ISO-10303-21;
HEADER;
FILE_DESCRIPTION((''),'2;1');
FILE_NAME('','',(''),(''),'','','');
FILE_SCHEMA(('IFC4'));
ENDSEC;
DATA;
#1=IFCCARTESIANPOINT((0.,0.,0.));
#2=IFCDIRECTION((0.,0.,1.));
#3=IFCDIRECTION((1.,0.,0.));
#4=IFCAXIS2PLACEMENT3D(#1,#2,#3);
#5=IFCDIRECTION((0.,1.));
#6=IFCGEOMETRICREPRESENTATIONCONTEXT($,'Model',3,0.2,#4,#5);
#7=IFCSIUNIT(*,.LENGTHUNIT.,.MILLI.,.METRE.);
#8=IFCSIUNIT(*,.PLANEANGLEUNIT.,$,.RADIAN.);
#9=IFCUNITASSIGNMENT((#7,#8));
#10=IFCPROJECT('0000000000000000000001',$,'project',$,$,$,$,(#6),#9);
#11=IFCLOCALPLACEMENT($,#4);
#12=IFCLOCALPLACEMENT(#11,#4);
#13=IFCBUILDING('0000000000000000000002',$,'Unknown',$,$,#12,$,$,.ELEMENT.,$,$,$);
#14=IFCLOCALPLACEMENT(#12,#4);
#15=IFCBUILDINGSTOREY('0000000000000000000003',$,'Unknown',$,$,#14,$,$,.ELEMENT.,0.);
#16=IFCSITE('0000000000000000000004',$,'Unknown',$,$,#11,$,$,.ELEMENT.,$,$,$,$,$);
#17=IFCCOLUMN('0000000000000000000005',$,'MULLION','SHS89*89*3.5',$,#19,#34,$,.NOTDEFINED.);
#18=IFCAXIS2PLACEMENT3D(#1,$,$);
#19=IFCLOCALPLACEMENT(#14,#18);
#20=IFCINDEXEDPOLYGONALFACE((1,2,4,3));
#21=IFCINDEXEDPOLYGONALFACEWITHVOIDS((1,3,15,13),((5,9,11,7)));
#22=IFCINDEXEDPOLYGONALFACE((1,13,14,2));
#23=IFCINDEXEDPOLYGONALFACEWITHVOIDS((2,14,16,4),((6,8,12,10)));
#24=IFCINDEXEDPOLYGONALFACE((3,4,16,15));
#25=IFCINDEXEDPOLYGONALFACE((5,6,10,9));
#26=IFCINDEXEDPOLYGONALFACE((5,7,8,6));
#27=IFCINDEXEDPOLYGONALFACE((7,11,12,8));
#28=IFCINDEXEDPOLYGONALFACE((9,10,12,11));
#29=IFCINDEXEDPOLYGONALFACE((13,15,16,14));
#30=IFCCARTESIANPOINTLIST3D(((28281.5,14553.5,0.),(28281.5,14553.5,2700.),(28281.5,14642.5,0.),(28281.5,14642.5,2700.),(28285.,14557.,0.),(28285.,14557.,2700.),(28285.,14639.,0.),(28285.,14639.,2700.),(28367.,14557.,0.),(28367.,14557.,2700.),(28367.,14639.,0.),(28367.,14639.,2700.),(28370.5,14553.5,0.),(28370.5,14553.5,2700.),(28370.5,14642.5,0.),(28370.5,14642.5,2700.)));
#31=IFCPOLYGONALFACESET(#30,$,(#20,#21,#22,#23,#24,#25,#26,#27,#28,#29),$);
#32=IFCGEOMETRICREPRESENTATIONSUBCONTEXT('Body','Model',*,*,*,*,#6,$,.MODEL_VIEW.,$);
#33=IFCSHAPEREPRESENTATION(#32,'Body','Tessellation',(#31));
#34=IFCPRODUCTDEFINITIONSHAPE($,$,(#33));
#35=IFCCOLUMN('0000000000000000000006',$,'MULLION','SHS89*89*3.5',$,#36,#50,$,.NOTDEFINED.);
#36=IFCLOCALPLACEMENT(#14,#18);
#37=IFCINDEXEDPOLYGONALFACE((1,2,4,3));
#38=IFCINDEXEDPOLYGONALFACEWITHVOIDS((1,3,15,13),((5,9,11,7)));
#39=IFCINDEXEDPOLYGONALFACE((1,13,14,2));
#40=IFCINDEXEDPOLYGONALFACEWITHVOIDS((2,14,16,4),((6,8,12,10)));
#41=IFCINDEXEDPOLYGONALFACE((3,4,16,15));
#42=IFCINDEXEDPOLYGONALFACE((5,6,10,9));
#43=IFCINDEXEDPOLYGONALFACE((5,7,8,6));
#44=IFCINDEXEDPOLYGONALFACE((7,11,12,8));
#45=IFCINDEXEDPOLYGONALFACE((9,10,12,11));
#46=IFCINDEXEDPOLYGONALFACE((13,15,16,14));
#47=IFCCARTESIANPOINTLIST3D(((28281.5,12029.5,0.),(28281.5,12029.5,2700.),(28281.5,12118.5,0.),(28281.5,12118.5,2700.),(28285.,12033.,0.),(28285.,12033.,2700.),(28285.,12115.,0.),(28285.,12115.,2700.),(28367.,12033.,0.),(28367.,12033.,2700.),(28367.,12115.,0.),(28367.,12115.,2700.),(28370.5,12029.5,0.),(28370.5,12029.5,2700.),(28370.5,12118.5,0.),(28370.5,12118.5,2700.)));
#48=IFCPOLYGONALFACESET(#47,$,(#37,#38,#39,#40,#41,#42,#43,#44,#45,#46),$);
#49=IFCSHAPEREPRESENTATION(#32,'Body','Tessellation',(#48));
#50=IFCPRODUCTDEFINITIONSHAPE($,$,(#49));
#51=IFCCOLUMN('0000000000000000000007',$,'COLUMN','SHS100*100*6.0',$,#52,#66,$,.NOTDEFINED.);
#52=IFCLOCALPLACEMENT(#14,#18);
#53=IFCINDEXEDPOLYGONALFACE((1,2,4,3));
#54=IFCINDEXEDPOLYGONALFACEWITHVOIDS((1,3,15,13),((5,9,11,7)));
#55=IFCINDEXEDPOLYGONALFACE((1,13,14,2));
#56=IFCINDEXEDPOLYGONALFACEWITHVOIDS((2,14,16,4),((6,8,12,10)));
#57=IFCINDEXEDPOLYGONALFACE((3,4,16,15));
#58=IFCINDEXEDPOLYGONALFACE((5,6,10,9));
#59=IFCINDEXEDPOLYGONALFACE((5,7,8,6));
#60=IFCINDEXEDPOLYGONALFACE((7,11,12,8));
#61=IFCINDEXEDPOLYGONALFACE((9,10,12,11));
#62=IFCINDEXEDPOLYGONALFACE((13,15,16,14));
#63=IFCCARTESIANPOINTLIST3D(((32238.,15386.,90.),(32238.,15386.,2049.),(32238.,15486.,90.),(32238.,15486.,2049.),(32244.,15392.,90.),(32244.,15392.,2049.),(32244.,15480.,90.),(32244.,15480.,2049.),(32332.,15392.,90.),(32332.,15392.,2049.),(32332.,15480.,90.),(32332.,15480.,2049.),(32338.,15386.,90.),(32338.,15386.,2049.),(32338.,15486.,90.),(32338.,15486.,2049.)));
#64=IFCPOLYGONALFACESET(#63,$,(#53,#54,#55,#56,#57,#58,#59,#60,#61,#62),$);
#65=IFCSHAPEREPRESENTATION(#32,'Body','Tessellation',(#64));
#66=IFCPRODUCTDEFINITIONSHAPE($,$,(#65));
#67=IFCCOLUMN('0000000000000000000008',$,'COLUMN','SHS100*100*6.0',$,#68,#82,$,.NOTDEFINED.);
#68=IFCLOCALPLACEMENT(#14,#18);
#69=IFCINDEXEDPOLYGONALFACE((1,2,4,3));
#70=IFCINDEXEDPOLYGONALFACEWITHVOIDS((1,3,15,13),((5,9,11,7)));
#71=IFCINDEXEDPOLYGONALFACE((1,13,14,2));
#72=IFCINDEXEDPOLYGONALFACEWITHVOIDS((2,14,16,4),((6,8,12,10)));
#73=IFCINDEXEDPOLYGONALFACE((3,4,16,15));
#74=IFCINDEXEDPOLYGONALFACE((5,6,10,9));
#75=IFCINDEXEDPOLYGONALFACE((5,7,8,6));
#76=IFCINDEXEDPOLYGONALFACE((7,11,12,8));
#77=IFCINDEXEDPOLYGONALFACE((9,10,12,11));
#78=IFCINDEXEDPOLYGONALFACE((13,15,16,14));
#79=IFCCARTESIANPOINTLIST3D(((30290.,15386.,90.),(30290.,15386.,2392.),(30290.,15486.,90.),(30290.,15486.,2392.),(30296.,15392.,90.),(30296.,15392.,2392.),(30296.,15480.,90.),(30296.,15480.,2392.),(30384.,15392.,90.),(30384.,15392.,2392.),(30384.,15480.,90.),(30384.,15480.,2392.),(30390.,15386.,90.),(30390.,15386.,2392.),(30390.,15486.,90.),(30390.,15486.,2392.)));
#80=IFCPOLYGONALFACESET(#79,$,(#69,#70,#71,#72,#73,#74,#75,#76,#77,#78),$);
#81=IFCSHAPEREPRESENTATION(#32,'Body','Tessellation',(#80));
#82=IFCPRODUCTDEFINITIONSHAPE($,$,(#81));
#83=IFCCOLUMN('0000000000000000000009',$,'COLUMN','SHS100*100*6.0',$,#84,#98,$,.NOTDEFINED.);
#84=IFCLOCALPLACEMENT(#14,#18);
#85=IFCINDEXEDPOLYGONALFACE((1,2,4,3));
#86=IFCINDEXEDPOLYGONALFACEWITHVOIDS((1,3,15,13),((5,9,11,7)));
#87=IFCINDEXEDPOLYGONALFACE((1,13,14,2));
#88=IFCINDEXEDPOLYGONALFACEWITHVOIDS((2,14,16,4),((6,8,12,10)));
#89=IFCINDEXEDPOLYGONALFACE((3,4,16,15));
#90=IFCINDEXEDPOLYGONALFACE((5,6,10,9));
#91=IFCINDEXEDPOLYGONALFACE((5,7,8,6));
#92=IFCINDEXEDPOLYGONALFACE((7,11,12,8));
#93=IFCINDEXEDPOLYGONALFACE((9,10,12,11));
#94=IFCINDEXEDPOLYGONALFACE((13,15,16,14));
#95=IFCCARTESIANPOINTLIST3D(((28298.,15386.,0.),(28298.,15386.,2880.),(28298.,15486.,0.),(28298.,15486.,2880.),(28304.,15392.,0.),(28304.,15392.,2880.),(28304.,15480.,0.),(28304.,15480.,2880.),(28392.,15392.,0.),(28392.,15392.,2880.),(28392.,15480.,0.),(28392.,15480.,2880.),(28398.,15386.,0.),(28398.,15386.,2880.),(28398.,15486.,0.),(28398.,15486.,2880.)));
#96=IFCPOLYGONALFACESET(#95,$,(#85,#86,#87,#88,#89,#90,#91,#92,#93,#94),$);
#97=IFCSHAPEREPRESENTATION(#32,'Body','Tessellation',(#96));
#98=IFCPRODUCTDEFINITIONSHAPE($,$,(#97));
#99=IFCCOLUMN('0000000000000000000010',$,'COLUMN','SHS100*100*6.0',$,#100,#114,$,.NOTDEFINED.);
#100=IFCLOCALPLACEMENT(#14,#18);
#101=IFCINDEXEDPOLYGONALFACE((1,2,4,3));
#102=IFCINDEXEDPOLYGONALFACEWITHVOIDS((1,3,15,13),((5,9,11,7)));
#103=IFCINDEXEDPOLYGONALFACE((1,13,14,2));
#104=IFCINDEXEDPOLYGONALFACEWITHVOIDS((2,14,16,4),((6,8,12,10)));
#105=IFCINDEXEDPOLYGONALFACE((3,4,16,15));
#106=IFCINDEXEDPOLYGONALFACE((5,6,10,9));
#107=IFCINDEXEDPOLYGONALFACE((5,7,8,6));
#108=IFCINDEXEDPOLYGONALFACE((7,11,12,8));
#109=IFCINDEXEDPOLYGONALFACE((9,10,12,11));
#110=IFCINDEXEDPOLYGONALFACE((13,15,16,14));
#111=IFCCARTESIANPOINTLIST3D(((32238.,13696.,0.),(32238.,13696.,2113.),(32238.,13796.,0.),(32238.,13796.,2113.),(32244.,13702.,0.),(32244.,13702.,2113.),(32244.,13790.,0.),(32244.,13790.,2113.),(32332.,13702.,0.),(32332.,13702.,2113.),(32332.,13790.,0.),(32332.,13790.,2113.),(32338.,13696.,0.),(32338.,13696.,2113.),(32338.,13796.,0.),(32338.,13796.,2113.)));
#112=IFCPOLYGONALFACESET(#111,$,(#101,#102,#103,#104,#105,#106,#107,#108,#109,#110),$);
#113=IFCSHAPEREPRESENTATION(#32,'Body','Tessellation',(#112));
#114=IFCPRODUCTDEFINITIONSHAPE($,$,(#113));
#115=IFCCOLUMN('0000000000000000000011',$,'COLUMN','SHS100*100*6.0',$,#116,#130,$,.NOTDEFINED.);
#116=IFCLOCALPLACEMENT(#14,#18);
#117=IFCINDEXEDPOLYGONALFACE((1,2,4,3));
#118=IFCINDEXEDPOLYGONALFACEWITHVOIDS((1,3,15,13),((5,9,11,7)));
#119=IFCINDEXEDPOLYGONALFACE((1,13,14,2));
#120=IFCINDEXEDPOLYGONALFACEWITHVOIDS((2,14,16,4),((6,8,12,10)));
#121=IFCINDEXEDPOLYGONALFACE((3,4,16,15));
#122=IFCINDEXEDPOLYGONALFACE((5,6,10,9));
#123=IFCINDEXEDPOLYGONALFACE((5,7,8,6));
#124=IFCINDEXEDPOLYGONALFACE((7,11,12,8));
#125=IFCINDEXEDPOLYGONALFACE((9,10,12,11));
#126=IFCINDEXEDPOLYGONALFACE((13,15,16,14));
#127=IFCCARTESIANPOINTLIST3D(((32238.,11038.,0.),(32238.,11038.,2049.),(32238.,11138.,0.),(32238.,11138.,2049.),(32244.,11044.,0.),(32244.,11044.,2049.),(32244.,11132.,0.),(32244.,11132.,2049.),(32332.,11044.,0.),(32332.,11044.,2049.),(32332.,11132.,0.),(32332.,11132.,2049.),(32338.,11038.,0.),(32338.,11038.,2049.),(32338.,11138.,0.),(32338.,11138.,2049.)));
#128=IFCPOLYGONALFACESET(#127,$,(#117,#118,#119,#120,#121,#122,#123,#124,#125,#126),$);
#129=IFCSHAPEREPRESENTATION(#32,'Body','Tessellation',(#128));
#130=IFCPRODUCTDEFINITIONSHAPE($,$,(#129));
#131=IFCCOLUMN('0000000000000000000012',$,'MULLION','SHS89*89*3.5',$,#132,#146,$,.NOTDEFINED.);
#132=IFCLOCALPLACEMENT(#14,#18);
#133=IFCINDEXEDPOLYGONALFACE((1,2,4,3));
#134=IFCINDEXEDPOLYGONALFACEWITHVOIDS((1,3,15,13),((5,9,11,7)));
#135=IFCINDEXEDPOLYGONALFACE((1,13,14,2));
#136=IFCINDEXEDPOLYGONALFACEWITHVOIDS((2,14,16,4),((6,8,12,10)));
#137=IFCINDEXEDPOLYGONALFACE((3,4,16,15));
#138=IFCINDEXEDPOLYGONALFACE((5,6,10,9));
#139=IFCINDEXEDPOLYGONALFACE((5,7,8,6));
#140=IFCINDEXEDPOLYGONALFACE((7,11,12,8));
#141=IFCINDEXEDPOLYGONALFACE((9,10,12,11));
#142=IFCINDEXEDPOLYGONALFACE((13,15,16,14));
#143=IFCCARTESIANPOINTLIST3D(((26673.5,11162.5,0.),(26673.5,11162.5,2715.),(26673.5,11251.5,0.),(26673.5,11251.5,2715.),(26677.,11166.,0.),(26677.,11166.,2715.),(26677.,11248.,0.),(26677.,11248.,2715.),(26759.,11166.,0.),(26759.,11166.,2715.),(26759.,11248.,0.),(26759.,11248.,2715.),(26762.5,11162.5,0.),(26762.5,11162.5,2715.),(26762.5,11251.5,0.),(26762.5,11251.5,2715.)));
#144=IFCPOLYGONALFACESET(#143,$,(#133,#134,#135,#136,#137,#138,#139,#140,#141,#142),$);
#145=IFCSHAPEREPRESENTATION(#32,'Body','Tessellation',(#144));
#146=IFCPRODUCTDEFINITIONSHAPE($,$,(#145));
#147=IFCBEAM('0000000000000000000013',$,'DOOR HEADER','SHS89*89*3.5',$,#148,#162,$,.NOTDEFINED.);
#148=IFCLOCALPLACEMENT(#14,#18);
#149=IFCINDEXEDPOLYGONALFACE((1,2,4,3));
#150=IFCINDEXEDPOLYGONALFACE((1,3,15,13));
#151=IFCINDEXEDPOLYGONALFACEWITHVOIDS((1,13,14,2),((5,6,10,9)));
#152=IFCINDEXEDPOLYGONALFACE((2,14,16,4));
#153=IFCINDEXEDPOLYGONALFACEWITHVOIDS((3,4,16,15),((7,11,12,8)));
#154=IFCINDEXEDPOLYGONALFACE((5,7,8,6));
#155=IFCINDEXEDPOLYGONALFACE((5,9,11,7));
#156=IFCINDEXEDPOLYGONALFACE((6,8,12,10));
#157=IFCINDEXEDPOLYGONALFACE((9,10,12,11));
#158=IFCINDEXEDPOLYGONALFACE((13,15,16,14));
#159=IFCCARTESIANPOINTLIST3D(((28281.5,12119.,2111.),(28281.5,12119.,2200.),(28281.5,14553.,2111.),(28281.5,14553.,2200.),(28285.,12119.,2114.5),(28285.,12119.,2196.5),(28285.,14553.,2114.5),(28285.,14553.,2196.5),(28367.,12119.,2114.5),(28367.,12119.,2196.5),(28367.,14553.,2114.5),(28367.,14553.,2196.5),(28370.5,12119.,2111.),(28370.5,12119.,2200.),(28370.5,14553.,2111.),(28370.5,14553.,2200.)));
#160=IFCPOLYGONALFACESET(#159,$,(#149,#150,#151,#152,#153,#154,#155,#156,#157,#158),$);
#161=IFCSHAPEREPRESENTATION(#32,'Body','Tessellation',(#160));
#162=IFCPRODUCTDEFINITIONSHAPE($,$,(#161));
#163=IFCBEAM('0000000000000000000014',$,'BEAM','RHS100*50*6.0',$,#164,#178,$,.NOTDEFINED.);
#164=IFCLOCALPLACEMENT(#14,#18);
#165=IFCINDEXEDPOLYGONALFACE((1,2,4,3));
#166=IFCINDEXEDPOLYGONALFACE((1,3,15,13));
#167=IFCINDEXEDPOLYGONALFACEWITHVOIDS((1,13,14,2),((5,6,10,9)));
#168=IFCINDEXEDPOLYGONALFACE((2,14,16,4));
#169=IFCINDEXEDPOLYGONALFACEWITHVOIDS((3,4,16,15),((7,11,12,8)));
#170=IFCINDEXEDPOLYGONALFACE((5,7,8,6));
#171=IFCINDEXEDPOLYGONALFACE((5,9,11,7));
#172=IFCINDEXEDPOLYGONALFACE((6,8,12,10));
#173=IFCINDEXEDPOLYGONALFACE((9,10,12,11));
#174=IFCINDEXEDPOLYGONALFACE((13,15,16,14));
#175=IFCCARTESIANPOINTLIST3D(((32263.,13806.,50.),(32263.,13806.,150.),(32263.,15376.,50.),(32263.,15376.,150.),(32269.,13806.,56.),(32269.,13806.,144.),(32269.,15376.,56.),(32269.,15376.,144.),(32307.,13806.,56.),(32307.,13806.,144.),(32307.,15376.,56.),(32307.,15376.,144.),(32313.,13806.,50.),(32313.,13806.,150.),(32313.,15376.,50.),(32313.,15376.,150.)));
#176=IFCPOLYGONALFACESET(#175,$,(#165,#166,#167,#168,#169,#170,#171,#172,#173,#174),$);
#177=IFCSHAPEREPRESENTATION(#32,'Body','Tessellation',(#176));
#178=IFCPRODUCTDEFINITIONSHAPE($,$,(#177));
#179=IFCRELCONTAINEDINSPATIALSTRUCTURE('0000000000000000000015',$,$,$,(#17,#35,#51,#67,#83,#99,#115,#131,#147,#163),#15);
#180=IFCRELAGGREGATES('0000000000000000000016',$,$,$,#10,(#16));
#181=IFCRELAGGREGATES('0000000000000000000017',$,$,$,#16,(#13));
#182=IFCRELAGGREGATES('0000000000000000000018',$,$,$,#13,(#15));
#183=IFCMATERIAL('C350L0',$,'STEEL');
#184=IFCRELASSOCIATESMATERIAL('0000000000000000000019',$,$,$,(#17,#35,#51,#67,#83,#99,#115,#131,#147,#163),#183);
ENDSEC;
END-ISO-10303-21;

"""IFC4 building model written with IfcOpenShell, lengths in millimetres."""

from ifc_helpers import new_model, si_unit, direction, frame, origin_with_axes, place, context, subcontext, project, spatial, line, indexed_curve, outline, extrude, material, element, save


model = new_model("IFC4")

# Units and contexts
model_context = context("Model", 3, precision=0.2, world=origin_with_axes(), true_north=direction((0.0, 1.0)))
body_context = subcontext(model_context, "Body", "Model", "MODEL_VIEW")
ifc_project = project(units=[si_unit("LENGTHUNIT", "METRE", prefix="MILLI"), si_unit("PLANEANGLEUNIT", "RADIAN")], contexts=[model_context])

# Site, building, storey
site_placement = place(None, origin_with_axes())
site = spatial("IfcSite", under=ifc_project, at=site_placement, Name="Unknown", CompositionType="ELEMENT")
building_placement = place(site_placement, origin_with_axes())
building = spatial("IfcBuilding", under=site, at=building_placement, Name="Unknown", CompositionType="ELEMENT")
storey_placement = place(building_placement, origin_with_axes())
storey = spatial("IfcBuildingStorey", under=building, at=storey_placement, Name="Unknown", CompositionType="ELEMENT", Elevation=0.0)

# Columns
ifc_material_1 = material(Name="C350L0", Category="STEEL")
for number, where, z_axis, x_axis, name in (
    (1, (28326.0, 14598.0, 0.0), (-1.0, 0.0, 0.0), (0.0, 0.0, 1.0), "MULLION"),
    (2, (28326.0, 12074.0, 0.0), (-1.0, 0.0, 0.0), (0.0, 0.0, 1.0), "MULLION"),
):
    element("IfcColumn", number, at=place(storey_placement, frame(where, z_axis=z_axis, x_axis=x_axis)), inside=storey, material=ifc_material_1, Name=name, Description="SHS89*89*3.5", PredefinedType="NOTDEFINED", context=body_context, shape_type="SolidModel", body=[
        extrude(outline(indexed_curve([(-44.5, -44.5), (44.5, -44.5), (44.5, 44.5), (-44.5, 44.5)], segments=[line(1, 2, 3, 4, 1)]), holes=[indexed_curve([(-41.0, -41.0), (-41.0, 41.0), (41.0, 41.0), (41.0, -41.0)], segments=[line(1, 2, 3, 4, 1)])]), frame((0.0, 0.0, 0.0), z_axis=(-1.0, 0.0, 0.0), x_axis=(0.0, 0.0, 1.0)), (0.0, 0.0, -1.0), 2700.0),
    ])
column_1_placement = place(storey_placement, frame((32288.0, 15436.0, 90.0), z_axis=(-1.0, 0.0, 0.0), x_axis=(0.0, 0.0, 1.0)))
element("IfcColumn", 3, at=column_1_placement, inside=storey, material=ifc_material_1, Name="COLUMN", Description="SHS100*100*6.0", PredefinedType="NOTDEFINED", context=body_context, shape_type="SolidModel", body=[
    extrude(outline(indexed_curve([(-50.0, -50.0), (50.0, -50.0), (50.0, 50.0), (-50.0, 50.0)], segments=[line(1, 2, 3, 4, 1)]), holes=[indexed_curve([(-44.0, -44.0), (-44.0, 44.0), (44.0, 44.0), (44.0, -44.0)], segments=[line(1, 2, 3, 4, 1)])]), frame((0.0, 0.0, 0.0), z_axis=(-1.0, 0.0, 0.0), x_axis=(0.0, 0.0, 1.0)), (0.0, 0.0, -1.0), 1959.0),
])
column_2_placement = place(storey_placement, frame((30340.0, 15436.0, 90.0), z_axis=(-1.0, 0.0, 0.0), x_axis=(0.0, 0.0, 1.0)))
element("IfcColumn", 4, at=column_2_placement, inside=storey, material=ifc_material_1, Name="COLUMN", Description="SHS100*100*6.0", PredefinedType="NOTDEFINED", context=body_context, shape_type="SolidModel", body=[
    extrude(outline(indexed_curve([(-50.0, -50.0), (50.0, -50.0), (50.0, 50.0), (-50.0, 50.0)], segments=[line(1, 2, 3, 4, 1)]), holes=[indexed_curve([(-44.0, -44.0), (-44.0, 44.0), (44.0, 44.0), (44.0, -44.0)], segments=[line(1, 2, 3, 4, 1)])]), frame((0.0, 0.0, 0.0), z_axis=(-1.0, 0.0, 0.0), x_axis=(0.0, 0.0, 1.0)), (0.0, 0.0, -1.0), 2302.0),
])
column_3_placement = place(storey_placement, frame((28348.0, 15436.0, 0.0), z_axis=(-1.0, 0.0, 0.0), x_axis=(0.0, 0.0, 1.0)))
element("IfcColumn", 5, at=column_3_placement, inside=storey, material=ifc_material_1, Name="COLUMN", Description="SHS100*100*6.0", PredefinedType="NOTDEFINED", context=body_context, shape_type="SolidModel", body=[
    extrude(outline(indexed_curve([(-50.0, -50.0), (50.0, -50.0), (50.0, 50.0), (-50.0, 50.0)], segments=[line(1, 2, 3, 4, 1)]), holes=[indexed_curve([(-44.0, -44.0), (-44.0, 44.0), (44.0, 44.0), (44.0, -44.0)], segments=[line(1, 2, 3, 4, 1)])]), frame((0.0, 0.0, 0.0), z_axis=(-1.0, 0.0, 0.0), x_axis=(0.0, 0.0, 1.0)), (0.0, 0.0, -1.0), 2880.0),
])
column_4_placement = place(storey_placement, frame((32288.0, 13746.0, 0.0), z_axis=(-1.0, 0.0, 0.0), x_axis=(0.0, 0.0, 1.0)))
element("IfcColumn", 6, at=column_4_placement, inside=storey, material=ifc_material_1, Name="COLUMN", Description="SHS100*100*6.0", PredefinedType="NOTDEFINED", context=body_context, shape_type="SolidModel", body=[
    extrude(outline(indexed_curve([(-50.0, -50.0), (50.0, -50.0), (50.0, 50.0), (-50.0, 50.0)], segments=[line(1, 2, 3, 4, 1)]), holes=[indexed_curve([(-44.0, -44.0), (-44.0, 44.0), (44.0, 44.0), (44.0, -44.0)], segments=[line(1, 2, 3, 4, 1)])]), frame((0.0, 0.0, 0.0), z_axis=(-1.0, 0.0, 0.0), x_axis=(0.0, 0.0, 1.0)), (0.0, 0.0, -1.0), 2113.0),
])
column_5_placement = place(storey_placement, frame((32288.0, 11088.0, 0.0), z_axis=(-1.0, 0.0, 0.0), x_axis=(0.0, 0.0, 1.0)))
element("IfcColumn", 7, at=column_5_placement, inside=storey, material=ifc_material_1, Name="COLUMN", Description="SHS100*100*6.0", PredefinedType="NOTDEFINED", context=body_context, shape_type="SolidModel", body=[
    extrude(outline(indexed_curve([(-50.0, -50.0), (50.0, -50.0), (50.0, 50.0), (-50.0, 50.0)], segments=[line(1, 2, 3, 4, 1)]), holes=[indexed_curve([(-44.0, -44.0), (-44.0, 44.0), (44.0, 44.0), (44.0, -44.0)], segments=[line(1, 2, 3, 4, 1)])]), frame((0.0, 0.0, 0.0), z_axis=(-1.0, 0.0, 0.0), x_axis=(0.0, 0.0, 1.0)), (0.0, 0.0, -1.0), 2049.0),
])
column_6_placement = place(storey_placement, frame((26718.0, 11207.0, 0.0), z_axis=(-1.0, 0.0, 0.0), x_axis=(0.0, 0.0, 1.0)))
element("IfcColumn", 8, at=column_6_placement, inside=storey, material=ifc_material_1, Name="MULLION", Description="SHS89*89*3.5", PredefinedType="NOTDEFINED", context=body_context, shape_type="SolidModel", body=[
    extrude(outline(indexed_curve([(-44.5, -44.5), (44.5, -44.5), (44.5, 44.5), (-44.5, 44.5)], segments=[line(1, 2, 3, 4, 1)]), holes=[indexed_curve([(-41.0, -41.0), (-41.0, 41.0), (41.0, 41.0), (41.0, -41.0)], segments=[line(1, 2, 3, 4, 1)])]), frame((0.0, 0.0, 0.0), z_axis=(-1.0, 0.0, 0.0), x_axis=(0.0, 0.0, 1.0)), (0.0, 0.0, -1.0), 2715.0),
])

# Beams
beam_1_placement = place(storey_placement, frame((28326.0, 12119.0, 2155.5), z_axis=(0.0, 0.0, 1.0), x_axis=(0.0, 1.0, 0.0)))
element("IfcBeam", 9, at=beam_1_placement, inside=storey, material=ifc_material_1, Name="DOOR HEADER", Description="SHS89*89*3.5", PredefinedType="NOTDEFINED", context=body_context, shape_type="SolidModel", body=[
    extrude(outline(indexed_curve([(-44.5, -44.5), (44.5, -44.5), (44.5, 44.5), (-44.5, 44.5)], segments=[line(1, 2, 3, 4, 1)]), holes=[indexed_curve([(-41.0, -41.0), (-41.0, 41.0), (41.0, 41.0), (41.0, -41.0)], segments=[line(1, 2, 3, 4, 1)])]), frame((0.0, 0.0, 0.0), z_axis=(-1.0, 0.0, 0.0), x_axis=(0.0, 0.0, 1.0)), (0.0, 0.0, -1.0), 2434.0),
])
beam_2_placement = place(storey_placement, frame((32288.0, 13806.0, 100.0), z_axis=(1.0, 0.0, 0.0), x_axis=(0.0, 1.0, 0.0)))
element("IfcBeam", 10, at=beam_2_placement, inside=storey, material=ifc_material_1, Name="BEAM", Description="RHS100*50*6.0", PredefinedType="NOTDEFINED", context=body_context, shape_type="SolidModel", body=[
    extrude(outline(indexed_curve([(-25.0, -50.0), (25.0, -50.0), (25.0, 50.0), (-25.0, 50.0)], segments=[line(1, 2, 3, 4, 1)]), holes=[indexed_curve([(-19.0, -44.0), (-19.0, 44.0), (19.0, 44.0), (19.0, -44.0)], segments=[line(1, 2, 3, 4, 1)])]), frame((0.0, 0.0, 0.0), z_axis=(-1.0, 0.0, 0.0), x_axis=(0.0, 0.0, 1.0)), (0.0, 0.0, -1.0), 1570.0),
])

save(model, "model.ifc")
